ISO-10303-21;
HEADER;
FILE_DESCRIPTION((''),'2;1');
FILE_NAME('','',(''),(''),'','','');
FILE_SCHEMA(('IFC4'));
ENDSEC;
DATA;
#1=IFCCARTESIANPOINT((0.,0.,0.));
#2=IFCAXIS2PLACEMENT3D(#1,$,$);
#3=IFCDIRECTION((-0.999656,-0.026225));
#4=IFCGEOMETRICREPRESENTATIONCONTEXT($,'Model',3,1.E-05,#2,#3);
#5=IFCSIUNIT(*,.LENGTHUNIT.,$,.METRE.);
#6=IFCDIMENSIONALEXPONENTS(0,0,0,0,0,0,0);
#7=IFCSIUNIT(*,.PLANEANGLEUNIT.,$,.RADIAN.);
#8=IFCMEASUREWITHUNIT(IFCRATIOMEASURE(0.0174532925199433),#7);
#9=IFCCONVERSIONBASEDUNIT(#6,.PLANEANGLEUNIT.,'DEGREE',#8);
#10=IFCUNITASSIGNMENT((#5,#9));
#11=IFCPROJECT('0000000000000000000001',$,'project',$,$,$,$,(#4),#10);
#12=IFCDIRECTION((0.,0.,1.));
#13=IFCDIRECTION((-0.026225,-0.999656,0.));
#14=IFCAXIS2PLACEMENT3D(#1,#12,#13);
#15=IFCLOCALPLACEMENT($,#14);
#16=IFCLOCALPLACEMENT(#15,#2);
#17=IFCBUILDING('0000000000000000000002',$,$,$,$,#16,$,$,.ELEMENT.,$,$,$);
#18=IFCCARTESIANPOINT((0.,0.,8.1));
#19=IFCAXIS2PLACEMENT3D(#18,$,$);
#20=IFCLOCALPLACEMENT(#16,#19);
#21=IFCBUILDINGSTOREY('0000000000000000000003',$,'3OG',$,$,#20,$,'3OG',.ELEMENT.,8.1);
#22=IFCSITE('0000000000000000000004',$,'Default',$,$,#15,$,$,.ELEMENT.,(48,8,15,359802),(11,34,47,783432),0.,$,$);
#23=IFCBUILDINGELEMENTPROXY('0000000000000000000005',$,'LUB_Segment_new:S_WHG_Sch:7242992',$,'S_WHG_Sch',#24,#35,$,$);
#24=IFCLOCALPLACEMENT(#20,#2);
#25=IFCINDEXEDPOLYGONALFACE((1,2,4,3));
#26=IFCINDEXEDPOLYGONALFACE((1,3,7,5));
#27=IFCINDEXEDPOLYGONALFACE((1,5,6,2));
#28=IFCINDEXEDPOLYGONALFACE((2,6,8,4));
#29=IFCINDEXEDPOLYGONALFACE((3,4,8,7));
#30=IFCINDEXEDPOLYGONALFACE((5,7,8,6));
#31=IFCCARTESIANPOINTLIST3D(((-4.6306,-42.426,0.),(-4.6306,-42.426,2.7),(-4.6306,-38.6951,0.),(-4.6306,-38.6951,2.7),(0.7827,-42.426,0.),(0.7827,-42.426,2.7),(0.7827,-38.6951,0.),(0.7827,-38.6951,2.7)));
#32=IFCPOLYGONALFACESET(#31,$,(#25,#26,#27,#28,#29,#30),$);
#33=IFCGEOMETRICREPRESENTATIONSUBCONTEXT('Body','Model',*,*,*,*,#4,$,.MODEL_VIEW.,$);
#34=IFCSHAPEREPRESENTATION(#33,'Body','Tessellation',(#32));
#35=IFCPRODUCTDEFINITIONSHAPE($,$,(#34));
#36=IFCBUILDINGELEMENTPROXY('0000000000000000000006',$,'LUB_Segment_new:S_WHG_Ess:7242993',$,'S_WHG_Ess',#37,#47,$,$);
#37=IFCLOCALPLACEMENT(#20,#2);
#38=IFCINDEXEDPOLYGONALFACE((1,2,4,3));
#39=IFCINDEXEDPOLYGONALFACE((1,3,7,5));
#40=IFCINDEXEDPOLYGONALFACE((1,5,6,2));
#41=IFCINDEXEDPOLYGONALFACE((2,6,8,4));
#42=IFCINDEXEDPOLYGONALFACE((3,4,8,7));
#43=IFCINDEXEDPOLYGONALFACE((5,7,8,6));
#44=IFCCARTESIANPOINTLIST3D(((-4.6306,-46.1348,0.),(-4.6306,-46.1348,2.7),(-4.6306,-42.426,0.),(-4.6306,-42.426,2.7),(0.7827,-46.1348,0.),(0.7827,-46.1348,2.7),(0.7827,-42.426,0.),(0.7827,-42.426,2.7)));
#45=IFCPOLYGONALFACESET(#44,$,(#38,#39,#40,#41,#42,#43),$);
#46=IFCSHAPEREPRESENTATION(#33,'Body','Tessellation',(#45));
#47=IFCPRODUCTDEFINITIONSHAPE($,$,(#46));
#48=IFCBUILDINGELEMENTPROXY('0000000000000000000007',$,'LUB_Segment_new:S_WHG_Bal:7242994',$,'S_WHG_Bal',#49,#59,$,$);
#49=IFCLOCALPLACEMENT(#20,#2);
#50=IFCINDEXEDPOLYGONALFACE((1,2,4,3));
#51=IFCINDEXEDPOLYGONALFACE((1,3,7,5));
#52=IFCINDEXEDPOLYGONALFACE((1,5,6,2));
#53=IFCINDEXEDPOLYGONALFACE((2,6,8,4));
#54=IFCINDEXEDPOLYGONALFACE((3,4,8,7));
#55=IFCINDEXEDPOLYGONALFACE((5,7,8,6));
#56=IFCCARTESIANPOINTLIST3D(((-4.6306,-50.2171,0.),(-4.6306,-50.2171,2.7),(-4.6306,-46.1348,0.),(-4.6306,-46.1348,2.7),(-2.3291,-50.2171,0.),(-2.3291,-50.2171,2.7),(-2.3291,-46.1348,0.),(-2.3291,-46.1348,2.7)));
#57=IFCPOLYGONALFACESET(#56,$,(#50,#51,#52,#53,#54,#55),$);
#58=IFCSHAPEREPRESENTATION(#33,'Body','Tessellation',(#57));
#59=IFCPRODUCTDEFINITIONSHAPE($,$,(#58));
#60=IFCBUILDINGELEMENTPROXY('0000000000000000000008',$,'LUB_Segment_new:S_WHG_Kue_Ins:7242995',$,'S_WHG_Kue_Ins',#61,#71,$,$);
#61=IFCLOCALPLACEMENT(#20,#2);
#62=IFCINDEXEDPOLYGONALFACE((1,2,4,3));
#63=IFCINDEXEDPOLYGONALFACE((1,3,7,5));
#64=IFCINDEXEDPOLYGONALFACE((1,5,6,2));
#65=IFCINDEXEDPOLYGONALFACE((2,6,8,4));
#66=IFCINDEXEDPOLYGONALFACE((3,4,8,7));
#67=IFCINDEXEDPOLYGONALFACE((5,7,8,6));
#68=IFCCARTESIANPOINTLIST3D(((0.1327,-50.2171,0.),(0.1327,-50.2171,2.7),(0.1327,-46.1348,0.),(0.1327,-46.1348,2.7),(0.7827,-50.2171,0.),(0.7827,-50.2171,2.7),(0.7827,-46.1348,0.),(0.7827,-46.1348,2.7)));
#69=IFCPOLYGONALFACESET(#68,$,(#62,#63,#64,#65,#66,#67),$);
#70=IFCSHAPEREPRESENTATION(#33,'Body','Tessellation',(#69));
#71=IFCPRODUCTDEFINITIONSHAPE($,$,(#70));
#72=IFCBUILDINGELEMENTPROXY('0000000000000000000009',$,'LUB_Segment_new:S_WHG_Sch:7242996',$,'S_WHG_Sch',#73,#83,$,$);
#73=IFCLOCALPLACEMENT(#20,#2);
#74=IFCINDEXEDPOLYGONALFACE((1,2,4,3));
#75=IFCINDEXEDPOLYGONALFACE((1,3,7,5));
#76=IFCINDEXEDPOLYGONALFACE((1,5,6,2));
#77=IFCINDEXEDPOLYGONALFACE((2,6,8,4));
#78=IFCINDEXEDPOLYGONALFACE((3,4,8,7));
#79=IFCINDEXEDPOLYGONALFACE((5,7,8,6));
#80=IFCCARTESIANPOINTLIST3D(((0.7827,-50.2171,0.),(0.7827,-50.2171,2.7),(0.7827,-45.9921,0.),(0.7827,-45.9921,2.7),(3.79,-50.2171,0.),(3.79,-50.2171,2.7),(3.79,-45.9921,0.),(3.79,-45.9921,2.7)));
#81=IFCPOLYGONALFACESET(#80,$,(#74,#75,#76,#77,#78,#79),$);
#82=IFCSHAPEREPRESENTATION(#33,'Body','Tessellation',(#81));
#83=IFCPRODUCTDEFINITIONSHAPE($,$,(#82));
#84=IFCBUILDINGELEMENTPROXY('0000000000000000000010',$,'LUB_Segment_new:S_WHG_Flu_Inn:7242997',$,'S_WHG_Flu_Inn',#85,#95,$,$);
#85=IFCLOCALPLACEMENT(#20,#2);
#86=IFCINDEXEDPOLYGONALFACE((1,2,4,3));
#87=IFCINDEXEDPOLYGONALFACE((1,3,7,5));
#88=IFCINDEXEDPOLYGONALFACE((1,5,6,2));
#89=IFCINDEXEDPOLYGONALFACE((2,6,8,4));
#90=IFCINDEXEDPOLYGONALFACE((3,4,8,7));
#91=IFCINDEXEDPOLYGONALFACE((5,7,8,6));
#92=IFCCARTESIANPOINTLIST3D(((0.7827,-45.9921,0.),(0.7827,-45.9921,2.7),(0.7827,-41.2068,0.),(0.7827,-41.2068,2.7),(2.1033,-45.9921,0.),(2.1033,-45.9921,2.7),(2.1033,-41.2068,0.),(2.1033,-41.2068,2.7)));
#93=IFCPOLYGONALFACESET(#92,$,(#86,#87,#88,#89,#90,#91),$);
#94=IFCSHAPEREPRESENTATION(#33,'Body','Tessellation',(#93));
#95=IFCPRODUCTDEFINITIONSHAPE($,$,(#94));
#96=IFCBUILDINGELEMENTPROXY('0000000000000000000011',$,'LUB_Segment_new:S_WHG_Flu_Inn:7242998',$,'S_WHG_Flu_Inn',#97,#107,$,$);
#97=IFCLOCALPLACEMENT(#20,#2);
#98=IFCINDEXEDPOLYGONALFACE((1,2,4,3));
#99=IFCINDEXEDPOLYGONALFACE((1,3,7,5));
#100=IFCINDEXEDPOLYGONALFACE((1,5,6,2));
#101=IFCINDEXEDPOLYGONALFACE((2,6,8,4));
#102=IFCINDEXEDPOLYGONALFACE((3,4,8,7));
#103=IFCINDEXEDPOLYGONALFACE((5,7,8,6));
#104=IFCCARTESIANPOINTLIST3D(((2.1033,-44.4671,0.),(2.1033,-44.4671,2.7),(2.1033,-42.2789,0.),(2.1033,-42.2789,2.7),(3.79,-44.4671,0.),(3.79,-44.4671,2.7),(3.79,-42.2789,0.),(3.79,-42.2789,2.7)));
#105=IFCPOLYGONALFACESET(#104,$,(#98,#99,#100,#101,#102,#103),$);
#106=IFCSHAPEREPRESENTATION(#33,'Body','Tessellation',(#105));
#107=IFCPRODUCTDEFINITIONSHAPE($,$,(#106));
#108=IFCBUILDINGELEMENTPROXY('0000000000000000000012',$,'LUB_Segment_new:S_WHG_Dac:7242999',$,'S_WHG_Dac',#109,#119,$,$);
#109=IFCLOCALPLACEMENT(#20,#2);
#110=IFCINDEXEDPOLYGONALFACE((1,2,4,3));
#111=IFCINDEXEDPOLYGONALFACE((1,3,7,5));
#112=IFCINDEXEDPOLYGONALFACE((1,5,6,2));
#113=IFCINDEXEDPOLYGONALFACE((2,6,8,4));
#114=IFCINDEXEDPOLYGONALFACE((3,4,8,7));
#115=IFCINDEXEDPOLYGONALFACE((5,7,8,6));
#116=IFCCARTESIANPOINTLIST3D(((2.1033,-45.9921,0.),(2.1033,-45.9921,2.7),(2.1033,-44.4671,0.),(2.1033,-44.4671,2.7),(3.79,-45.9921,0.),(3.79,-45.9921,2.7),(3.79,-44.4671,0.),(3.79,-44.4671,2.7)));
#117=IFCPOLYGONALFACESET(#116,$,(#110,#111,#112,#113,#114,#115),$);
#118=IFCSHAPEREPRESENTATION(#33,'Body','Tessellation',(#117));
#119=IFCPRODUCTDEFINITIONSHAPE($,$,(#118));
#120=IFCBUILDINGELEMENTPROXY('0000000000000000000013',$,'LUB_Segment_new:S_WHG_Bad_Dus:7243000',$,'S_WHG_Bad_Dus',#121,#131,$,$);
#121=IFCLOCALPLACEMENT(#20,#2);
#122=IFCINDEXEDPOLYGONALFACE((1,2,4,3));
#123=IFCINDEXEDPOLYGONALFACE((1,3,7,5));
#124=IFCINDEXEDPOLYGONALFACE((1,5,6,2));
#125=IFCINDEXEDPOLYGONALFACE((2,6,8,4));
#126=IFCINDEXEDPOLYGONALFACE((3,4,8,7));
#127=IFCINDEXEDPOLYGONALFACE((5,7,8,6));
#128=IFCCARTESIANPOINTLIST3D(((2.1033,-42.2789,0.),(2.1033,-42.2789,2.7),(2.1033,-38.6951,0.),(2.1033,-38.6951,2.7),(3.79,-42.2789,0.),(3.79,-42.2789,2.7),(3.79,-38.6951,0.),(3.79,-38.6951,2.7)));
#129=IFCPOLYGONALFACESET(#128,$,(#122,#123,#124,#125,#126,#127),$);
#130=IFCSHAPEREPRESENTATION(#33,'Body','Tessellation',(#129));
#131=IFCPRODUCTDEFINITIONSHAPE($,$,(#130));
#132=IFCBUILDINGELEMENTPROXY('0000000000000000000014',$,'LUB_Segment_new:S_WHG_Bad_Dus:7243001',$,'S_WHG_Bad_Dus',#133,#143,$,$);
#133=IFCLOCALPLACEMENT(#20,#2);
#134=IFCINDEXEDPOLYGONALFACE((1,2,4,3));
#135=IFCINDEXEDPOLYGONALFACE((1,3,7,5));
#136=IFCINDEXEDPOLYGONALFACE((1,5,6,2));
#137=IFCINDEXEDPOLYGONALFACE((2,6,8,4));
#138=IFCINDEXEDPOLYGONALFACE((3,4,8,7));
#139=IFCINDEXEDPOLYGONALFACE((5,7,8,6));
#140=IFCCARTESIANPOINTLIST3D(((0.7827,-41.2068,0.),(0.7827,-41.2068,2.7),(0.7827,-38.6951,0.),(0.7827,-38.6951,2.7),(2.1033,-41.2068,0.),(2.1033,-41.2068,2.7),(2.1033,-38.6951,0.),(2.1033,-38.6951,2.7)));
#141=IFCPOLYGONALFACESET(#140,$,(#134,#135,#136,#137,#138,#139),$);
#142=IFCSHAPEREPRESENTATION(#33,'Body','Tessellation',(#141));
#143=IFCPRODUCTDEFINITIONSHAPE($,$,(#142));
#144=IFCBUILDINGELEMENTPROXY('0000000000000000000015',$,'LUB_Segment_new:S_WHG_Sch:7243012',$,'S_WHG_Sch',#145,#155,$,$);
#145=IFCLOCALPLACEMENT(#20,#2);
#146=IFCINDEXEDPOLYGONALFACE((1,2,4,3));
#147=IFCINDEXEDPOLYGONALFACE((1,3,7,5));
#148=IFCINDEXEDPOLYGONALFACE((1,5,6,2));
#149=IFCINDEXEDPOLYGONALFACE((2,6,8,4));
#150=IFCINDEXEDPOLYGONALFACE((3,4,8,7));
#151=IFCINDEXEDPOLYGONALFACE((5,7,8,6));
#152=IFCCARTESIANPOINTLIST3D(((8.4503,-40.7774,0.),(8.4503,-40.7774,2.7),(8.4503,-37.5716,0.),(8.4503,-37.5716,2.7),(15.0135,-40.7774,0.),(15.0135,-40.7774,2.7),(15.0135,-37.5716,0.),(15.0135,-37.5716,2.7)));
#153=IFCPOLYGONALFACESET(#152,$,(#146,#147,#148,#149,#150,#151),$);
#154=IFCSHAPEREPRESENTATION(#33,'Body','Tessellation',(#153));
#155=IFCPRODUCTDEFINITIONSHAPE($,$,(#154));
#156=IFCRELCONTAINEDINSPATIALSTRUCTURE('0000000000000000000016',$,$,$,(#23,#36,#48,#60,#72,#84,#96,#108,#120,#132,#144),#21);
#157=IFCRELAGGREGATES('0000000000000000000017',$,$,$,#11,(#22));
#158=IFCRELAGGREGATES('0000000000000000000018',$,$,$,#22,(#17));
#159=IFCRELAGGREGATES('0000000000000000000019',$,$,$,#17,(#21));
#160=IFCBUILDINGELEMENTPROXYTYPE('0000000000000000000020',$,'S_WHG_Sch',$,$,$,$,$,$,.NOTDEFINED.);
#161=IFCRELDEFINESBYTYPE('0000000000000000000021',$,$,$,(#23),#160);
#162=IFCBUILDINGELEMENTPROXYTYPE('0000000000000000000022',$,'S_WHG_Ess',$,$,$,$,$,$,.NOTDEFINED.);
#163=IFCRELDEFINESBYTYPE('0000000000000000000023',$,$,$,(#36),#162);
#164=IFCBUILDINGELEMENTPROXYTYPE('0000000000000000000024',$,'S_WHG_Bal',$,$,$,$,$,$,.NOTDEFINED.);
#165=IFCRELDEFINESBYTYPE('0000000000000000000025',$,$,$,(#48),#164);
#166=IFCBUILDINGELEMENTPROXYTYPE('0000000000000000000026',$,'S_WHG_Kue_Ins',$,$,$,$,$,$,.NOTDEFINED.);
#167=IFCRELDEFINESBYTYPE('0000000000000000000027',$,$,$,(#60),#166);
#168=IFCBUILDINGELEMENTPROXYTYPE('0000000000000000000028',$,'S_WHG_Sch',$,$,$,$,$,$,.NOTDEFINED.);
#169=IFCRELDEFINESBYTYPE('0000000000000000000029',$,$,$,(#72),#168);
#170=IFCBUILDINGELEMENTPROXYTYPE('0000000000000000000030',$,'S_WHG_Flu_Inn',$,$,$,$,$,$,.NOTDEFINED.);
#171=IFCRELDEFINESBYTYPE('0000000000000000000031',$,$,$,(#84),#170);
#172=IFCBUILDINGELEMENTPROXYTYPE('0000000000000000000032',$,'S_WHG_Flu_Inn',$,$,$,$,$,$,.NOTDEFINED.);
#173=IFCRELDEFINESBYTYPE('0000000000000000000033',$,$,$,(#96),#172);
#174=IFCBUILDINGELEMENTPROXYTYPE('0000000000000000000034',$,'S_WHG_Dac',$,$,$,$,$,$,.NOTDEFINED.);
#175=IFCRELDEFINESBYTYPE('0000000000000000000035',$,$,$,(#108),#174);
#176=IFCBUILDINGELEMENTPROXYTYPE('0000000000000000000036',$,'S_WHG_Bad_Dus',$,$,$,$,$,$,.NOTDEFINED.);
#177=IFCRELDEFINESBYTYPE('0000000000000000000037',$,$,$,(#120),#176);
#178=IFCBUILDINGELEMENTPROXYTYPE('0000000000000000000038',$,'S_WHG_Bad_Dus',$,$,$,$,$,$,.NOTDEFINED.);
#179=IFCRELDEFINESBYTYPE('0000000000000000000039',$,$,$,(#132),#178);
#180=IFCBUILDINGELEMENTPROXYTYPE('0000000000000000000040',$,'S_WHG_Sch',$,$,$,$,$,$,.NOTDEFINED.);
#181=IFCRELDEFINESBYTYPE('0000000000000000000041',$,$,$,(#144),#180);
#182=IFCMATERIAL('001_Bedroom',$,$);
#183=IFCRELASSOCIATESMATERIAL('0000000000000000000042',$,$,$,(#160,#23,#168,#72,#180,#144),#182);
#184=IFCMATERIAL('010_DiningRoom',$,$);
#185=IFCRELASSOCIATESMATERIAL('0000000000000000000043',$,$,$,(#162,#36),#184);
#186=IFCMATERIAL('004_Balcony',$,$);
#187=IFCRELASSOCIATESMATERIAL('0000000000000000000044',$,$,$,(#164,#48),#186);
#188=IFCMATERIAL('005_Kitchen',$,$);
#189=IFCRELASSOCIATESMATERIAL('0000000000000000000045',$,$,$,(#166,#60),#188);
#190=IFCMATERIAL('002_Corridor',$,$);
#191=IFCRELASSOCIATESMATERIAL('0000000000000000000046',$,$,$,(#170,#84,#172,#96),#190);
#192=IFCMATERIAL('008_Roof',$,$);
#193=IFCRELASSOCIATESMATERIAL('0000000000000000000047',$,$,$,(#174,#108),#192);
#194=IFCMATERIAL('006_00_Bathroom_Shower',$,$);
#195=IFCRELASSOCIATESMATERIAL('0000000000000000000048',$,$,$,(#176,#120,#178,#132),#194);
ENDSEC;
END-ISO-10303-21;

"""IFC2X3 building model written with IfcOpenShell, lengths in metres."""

from ifc_helpers import new_model, entity, si_unit, converted_unit, direction, frame, frame_2d, origin, origin_2d_with_axis, place, context, subcontext, project, spatial, rectangle, extrude, source, transform, mapped, material, type_object, type_shapes, element, save


model = new_model("IFC2X3")

# Units and contexts
model_context = context("Model", 3, precision=1e-05, world=origin(), true_north=direction((-0.999656, -0.026225)))
body_context = subcontext(model_context, "Body", "Model", "MODEL_VIEW")
ifc_project = project(units=[si_unit("LENGTHUNIT", "METRE"), converted_unit("PLANEANGLEUNIT", "DEGREE", entity("IfcRatioMeasure", 0.0174532925199433), si_unit("PLANEANGLEUNIT", "RADIAN"), dimensions=[0, 0, 0, 0, 0, 0, 0])], contexts=[model_context])

# Site, building, storey
site_placement = place(None, frame((0.0, 0.0, 0.0), z_axis=(0.0, 0.0, 1.0), x_axis=(-0.026225, -0.999656, 0.0)))
site = spatial("IfcSite", under=ifc_project, at=site_placement, Name="Default", CompositionType="ELEMENT", RefLatitude=(48, 8, 15, 359802), RefLongitude=(11, 34, 47, 783432), RefElevation=0.0)
building_placement = place(site_placement, origin())
building = spatial("IfcBuilding", under=site, at=building_placement, CompositionType="ELEMENT")
storey_placement = place(building_placement, frame((0.0, 0.0, 8.1)))
storey = spatial("IfcBuildingStorey", under=building, at=storey_placement, Name="3OG", LongName="3OG", CompositionType="ELEMENT", Elevation=8.1)

# Building element proxies
ifc_material_1 = material(Name="001_Bedroom")
building_element_proxy_type_1 = type_object("IfcBuildingElementProxyType", Name="S_WHG_Sch", PredefinedType="NOTDEFINED", material=ifc_material_1)
shared_shape_1 = source(origin(), body_context, "Body", "SweptSolid", [
    extrude(rectangle(XDim=5.4132, YDim=3.7309, at=origin_2d_with_axis()), frame((0.0, 0.0, 0.0), z_axis=(0.0, 0.0, 1.0), x_axis=(-1.0, 0.0, 0.0)), (0.0, 0.0, 1.0), 2.7),
])
type_shapes(building_element_proxy_type_1, [shared_shape_1])
proxy_1_placement = place(storey_placement, frame((-1.924, -40.5605, 0.0)))
element("IfcBuildingElementProxy", 1, at=proxy_1_placement, inside=storey, type_object=building_element_proxy_type_1, material=ifc_material_1, Name="LUB_Segment_new:S_WHG_Sch:7242992", ObjectType="S_WHG_Sch", context=body_context, shape_type="MappedRepresentation", body=[
    mapped(shared_shape_1, transform((0.0, 0.0, 0.0), scale=1.0)),
])
ifc_material_2 = material(Name="010_DiningRoom")
building_element_proxy_type_2 = type_object("IfcBuildingElementProxyType", Name="S_WHG_Ess", PredefinedType="NOTDEFINED", material=ifc_material_2)
shared_shape_2 = source(origin(), body_context, "Body", "SweptSolid", [
    extrude(rectangle(XDim=5.4132, YDim=3.7088, at=origin_2d_with_axis()), frame((0.0, 0.0, 0.0), z_axis=(0.0, 0.0, 1.0), x_axis=(-1.0, 0.0, 0.0)), (0.0, 0.0, 1.0), 2.7),
])
type_shapes(building_element_proxy_type_2, [shared_shape_2])
proxy_2_placement = place(storey_placement, frame((-1.924, -44.2804, 0.0)))
element("IfcBuildingElementProxy", 2, at=proxy_2_placement, inside=storey, type_object=building_element_proxy_type_2, material=ifc_material_2, Name="LUB_Segment_new:S_WHG_Ess:7242993", ObjectType="S_WHG_Ess", context=body_context, shape_type="MappedRepresentation", body=[
    mapped(shared_shape_2, transform((0.0, 0.0, 0.0), scale=1.0)),
])
ifc_material_3 = material(Name="004_Balcony")
building_element_proxy_type_3 = type_object("IfcBuildingElementProxyType", Name="S_WHG_Bal", PredefinedType="NOTDEFINED", material=ifc_material_3)
shared_shape_3 = source(origin(), body_context, "Body", "SweptSolid", [
    extrude(rectangle(XDim=4.0824, YDim=2.3015, at=origin_2d_with_axis()), frame((0.0, 0.0, 0.0), z_axis=(0.0, 0.0, 1.0), x_axis=(0.0, 1.0, 0.0)), (0.0, 0.0, 1.0), 2.7),
])
type_shapes(building_element_proxy_type_3, [shared_shape_3])
proxy_3_placement = place(storey_placement, frame((-3.4798, -48.176, 0.0)))
element("IfcBuildingElementProxy", 3, at=proxy_3_placement, inside=storey, type_object=building_element_proxy_type_3, material=ifc_material_3, Name="LUB_Segment_new:S_WHG_Bal:7242994", ObjectType="S_WHG_Bal", context=body_context, shape_type="MappedRepresentation", body=[
    mapped(shared_shape_3, transform((0.0, 0.0, 0.0), scale=1.0)),
])
ifc_material_4 = material(Name="005_Kitchen")
building_element_proxy_type_4 = type_object("IfcBuildingElementProxyType", Name="S_WHG_Kue_Ins", PredefinedType="NOTDEFINED", material=ifc_material_4)
shared_shape_4 = source(origin(), body_context, "Body", "SweptSolid", [
    extrude(rectangle(XDim=4.0824, YDim=0.65, at=origin_2d_with_axis()), frame((0.0, 0.0, 0.0), z_axis=(0.0, 0.0, 1.0), x_axis=(0.0, 1.0, 0.0)), (0.0, 0.0, 1.0), 2.7),
])
type_shapes(building_element_proxy_type_4, [shared_shape_4])
proxy_4_placement = place(storey_placement, frame((0.4577, -48.176, 0.0)))
element("IfcBuildingElementProxy", 4, at=proxy_4_placement, inside=storey, type_object=building_element_proxy_type_4, material=ifc_material_4, Name="LUB_Segment_new:S_WHG_Kue_Ins:7242995", ObjectType="S_WHG_Kue_Ins", context=body_context, shape_type="MappedRepresentation", body=[
    mapped(shared_shape_4, transform((0.0, 0.0, 0.0), scale=1.0)),
])
building_element_proxy_type_5 = type_object("IfcBuildingElementProxyType", Name="S_WHG_Sch", PredefinedType="NOTDEFINED", material=ifc_material_1)
shared_shape_5 = source(origin(), body_context, "Body", "SweptSolid", [
    extrude(rectangle(XDim=4.225, YDim=3.0074, at=origin_2d_with_axis()), frame((0.0, 0.0, 0.0), z_axis=(0.0, 0.0, 1.0), x_axis=(0.0, 1.0, 0.0)), (0.0, 0.0, 1.0), 2.7),
])
type_shapes(building_element_proxy_type_5, [shared_shape_5])
proxy_5_placement = place(storey_placement, frame((2.2863, -48.1046, 0.0)))
element("IfcBuildingElementProxy", 5, at=proxy_5_placement, inside=storey, type_object=building_element_proxy_type_5, material=ifc_material_1, Name="LUB_Segment_new:S_WHG_Sch:7242996", ObjectType="S_WHG_Sch", context=body_context, shape_type="MappedRepresentation", body=[
    mapped(shared_shape_5, transform((0.0, 0.0, 0.0), scale=1.0)),
])
ifc_material_5 = material(Name="002_Corridor")
building_element_proxy_type_6 = type_object("IfcBuildingElementProxyType", Name="S_WHG_Flu_Inn", PredefinedType="NOTDEFINED", material=ifc_material_5)
shared_shape_6 = source(origin(), body_context, "Body", "SweptSolid", [
    extrude(rectangle(XDim=4.7853, YDim=1.3206, at=origin_2d_with_axis()), frame((0.0, 0.0, 0.0), z_axis=(0.0, 0.0, 1.0), x_axis=(0.0, 1.0, 0.0)), (0.0, 0.0, 1.0), 2.7),
])
type_shapes(building_element_proxy_type_6, [shared_shape_6])
proxy_6_placement = place(storey_placement, frame((1.443, -43.5995, 0.0)))
element("IfcBuildingElementProxy", 6, at=proxy_6_placement, inside=storey, type_object=building_element_proxy_type_6, material=ifc_material_5, Name="LUB_Segment_new:S_WHG_Flu_Inn:7242997", ObjectType="S_WHG_Flu_Inn", context=body_context, shape_type="MappedRepresentation", body=[
    mapped(shared_shape_6, transform((0.0, 0.0, 0.0), scale=1.0)),
])
building_element_proxy_type_7 = type_object("IfcBuildingElementProxyType", Name="S_WHG_Flu_Inn", PredefinedType="NOTDEFINED", material=ifc_material_5)
shared_shape_7 = source(origin(), body_context, "Body", "SweptSolid", [
    extrude(rectangle(XDim=2.1882, YDim=1.6868, at=origin_2d_with_axis()), frame((0.0, 0.0, 0.0), z_axis=(0.0, 0.0, 1.0), x_axis=(0.0, 1.0, 0.0)), (0.0, 0.0, 1.0), 2.7),
])
type_shapes(building_element_proxy_type_7, [shared_shape_7])
proxy_7_placement = place(storey_placement, frame((2.9466, -43.373, 0.0)))
element("IfcBuildingElementProxy", 7, at=proxy_7_placement, inside=storey, type_object=building_element_proxy_type_7, material=ifc_material_5, Name="LUB_Segment_new:S_WHG_Flu_Inn:7242998", ObjectType="S_WHG_Flu_Inn", context=body_context, shape_type="MappedRepresentation", body=[
    mapped(shared_shape_7, transform((0.0, 0.0, 0.0), scale=1.0)),
])
ifc_material_6 = material(Name="008_Roof")
building_element_proxy_type_8 = type_object("IfcBuildingElementProxyType", Name="S_WHG_Dac", PredefinedType="NOTDEFINED", material=ifc_material_6)
shared_shape_8 = source(origin(), body_context, "Body", "SweptSolid", [
    extrude(rectangle(XDim=1.525, YDim=1.6868, at=origin_2d_with_axis()), frame((0.0, 0.0, 0.0), z_axis=(0.0, 0.0, 1.0), x_axis=(0.0, 1.0, 0.0)), (0.0, 0.0, 1.0), 2.7),
])
type_shapes(building_element_proxy_type_8, [shared_shape_8])
proxy_8_placement = place(storey_placement, frame((2.9466, -45.2296, 0.0)))
element("IfcBuildingElementProxy", 8, at=proxy_8_placement, inside=storey, type_object=building_element_proxy_type_8, material=ifc_material_6, Name="LUB_Segment_new:S_WHG_Dac:7242999", ObjectType="S_WHG_Dac", context=body_context, shape_type="MappedRepresentation", body=[
    mapped(shared_shape_8, transform((0.0, 0.0, 0.0), scale=1.0)),
])
ifc_material_7 = material(Name="006_00_Bathroom_Shower")
building_element_proxy_type_9 = type_object("IfcBuildingElementProxyType", Name="S_WHG_Bad_Dus", PredefinedType="NOTDEFINED", material=ifc_material_7)
shared_shape_9 = source(origin(), body_context, "Body", "SweptSolid", [
    extrude(rectangle(XDim=3.5838, YDim=1.6868, at=origin_2d_with_axis()), frame((0.0, 0.0, 0.0), z_axis=(0.0, 0.0, 1.0), x_axis=(0.0, 1.0, 0.0)), (0.0, 0.0, 1.0), 2.7),
])
type_shapes(building_element_proxy_type_9, [shared_shape_9])
proxy_9_placement = place(storey_placement, frame((2.9466, -40.487, 0.0)))
element("IfcBuildingElementProxy", 9, at=proxy_9_placement, inside=storey, type_object=building_element_proxy_type_9, material=ifc_material_7, Name="LUB_Segment_new:S_WHG_Bad_Dus:7243000", ObjectType="S_WHG_Bad_Dus", context=body_context, shape_type="MappedRepresentation", body=[
    mapped(shared_shape_9, transform((0.0, 0.0, 0.0), scale=1.0)),
])
building_element_proxy_type_10 = type_object("IfcBuildingElementProxyType", Name="S_WHG_Bad_Dus", PredefinedType="NOTDEFINED", material=ifc_material_7)
shared_shape_10 = source(origin(), body_context, "Body", "SweptSolid", [
    extrude(rectangle(XDim=2.5118, YDim=1.3206, at=frame_2d((0.0, 0.0), x_axis=(1.0, 0.0))), frame((0.0, 0.0, 0.0), z_axis=(0.0, 0.0, 1.0), x_axis=(0.0, 1.0, 0.0)), (0.0, 0.0, 1.0), 2.7),
])
type_shapes(building_element_proxy_type_10, [shared_shape_10])
proxy_10_placement = place(storey_placement, frame((1.443, -39.951, 0.0)))
element("IfcBuildingElementProxy", 10, at=proxy_10_placement, inside=storey, type_object=building_element_proxy_type_10, material=ifc_material_7, Name="LUB_Segment_new:S_WHG_Bad_Dus:7243001", ObjectType="S_WHG_Bad_Dus", context=body_context, shape_type="MappedRepresentation", body=[
    mapped(shared_shape_10, transform((0.0, 0.0, 0.0), scale=1.0)),
])
building_element_proxy_type_11 = type_object("IfcBuildingElementProxyType", Name="S_WHG_Sch", PredefinedType="NOTDEFINED", material=ifc_material_1)
shared_shape_11 = source(origin(), body_context, "Body", "SweptSolid", [
    extrude(rectangle(XDim=6.5632, YDim=3.2059, at=origin_2d_with_axis()), frame((0.0, 0.0, 0.0), z_axis=(0.0, 0.0, 1.0), x_axis=(-1.0, 0.0, 0.0)), (0.0, 0.0, 1.0), 2.7),
])
type_shapes(building_element_proxy_type_11, [shared_shape_11])
proxy_11_placement = place(storey_placement, frame((11.7319, -39.1745, 0.0)))
element("IfcBuildingElementProxy", 11, at=proxy_11_placement, inside=storey, type_object=building_element_proxy_type_11, material=ifc_material_1, Name="LUB_Segment_new:S_WHG_Sch:7243012", ObjectType="S_WHG_Sch", context=body_context, shape_type="MappedRepresentation", body=[
    mapped(shared_shape_11, transform((0.0, 0.0, 0.0), scale=1.0)),
])

save(model, "model.ifc")
